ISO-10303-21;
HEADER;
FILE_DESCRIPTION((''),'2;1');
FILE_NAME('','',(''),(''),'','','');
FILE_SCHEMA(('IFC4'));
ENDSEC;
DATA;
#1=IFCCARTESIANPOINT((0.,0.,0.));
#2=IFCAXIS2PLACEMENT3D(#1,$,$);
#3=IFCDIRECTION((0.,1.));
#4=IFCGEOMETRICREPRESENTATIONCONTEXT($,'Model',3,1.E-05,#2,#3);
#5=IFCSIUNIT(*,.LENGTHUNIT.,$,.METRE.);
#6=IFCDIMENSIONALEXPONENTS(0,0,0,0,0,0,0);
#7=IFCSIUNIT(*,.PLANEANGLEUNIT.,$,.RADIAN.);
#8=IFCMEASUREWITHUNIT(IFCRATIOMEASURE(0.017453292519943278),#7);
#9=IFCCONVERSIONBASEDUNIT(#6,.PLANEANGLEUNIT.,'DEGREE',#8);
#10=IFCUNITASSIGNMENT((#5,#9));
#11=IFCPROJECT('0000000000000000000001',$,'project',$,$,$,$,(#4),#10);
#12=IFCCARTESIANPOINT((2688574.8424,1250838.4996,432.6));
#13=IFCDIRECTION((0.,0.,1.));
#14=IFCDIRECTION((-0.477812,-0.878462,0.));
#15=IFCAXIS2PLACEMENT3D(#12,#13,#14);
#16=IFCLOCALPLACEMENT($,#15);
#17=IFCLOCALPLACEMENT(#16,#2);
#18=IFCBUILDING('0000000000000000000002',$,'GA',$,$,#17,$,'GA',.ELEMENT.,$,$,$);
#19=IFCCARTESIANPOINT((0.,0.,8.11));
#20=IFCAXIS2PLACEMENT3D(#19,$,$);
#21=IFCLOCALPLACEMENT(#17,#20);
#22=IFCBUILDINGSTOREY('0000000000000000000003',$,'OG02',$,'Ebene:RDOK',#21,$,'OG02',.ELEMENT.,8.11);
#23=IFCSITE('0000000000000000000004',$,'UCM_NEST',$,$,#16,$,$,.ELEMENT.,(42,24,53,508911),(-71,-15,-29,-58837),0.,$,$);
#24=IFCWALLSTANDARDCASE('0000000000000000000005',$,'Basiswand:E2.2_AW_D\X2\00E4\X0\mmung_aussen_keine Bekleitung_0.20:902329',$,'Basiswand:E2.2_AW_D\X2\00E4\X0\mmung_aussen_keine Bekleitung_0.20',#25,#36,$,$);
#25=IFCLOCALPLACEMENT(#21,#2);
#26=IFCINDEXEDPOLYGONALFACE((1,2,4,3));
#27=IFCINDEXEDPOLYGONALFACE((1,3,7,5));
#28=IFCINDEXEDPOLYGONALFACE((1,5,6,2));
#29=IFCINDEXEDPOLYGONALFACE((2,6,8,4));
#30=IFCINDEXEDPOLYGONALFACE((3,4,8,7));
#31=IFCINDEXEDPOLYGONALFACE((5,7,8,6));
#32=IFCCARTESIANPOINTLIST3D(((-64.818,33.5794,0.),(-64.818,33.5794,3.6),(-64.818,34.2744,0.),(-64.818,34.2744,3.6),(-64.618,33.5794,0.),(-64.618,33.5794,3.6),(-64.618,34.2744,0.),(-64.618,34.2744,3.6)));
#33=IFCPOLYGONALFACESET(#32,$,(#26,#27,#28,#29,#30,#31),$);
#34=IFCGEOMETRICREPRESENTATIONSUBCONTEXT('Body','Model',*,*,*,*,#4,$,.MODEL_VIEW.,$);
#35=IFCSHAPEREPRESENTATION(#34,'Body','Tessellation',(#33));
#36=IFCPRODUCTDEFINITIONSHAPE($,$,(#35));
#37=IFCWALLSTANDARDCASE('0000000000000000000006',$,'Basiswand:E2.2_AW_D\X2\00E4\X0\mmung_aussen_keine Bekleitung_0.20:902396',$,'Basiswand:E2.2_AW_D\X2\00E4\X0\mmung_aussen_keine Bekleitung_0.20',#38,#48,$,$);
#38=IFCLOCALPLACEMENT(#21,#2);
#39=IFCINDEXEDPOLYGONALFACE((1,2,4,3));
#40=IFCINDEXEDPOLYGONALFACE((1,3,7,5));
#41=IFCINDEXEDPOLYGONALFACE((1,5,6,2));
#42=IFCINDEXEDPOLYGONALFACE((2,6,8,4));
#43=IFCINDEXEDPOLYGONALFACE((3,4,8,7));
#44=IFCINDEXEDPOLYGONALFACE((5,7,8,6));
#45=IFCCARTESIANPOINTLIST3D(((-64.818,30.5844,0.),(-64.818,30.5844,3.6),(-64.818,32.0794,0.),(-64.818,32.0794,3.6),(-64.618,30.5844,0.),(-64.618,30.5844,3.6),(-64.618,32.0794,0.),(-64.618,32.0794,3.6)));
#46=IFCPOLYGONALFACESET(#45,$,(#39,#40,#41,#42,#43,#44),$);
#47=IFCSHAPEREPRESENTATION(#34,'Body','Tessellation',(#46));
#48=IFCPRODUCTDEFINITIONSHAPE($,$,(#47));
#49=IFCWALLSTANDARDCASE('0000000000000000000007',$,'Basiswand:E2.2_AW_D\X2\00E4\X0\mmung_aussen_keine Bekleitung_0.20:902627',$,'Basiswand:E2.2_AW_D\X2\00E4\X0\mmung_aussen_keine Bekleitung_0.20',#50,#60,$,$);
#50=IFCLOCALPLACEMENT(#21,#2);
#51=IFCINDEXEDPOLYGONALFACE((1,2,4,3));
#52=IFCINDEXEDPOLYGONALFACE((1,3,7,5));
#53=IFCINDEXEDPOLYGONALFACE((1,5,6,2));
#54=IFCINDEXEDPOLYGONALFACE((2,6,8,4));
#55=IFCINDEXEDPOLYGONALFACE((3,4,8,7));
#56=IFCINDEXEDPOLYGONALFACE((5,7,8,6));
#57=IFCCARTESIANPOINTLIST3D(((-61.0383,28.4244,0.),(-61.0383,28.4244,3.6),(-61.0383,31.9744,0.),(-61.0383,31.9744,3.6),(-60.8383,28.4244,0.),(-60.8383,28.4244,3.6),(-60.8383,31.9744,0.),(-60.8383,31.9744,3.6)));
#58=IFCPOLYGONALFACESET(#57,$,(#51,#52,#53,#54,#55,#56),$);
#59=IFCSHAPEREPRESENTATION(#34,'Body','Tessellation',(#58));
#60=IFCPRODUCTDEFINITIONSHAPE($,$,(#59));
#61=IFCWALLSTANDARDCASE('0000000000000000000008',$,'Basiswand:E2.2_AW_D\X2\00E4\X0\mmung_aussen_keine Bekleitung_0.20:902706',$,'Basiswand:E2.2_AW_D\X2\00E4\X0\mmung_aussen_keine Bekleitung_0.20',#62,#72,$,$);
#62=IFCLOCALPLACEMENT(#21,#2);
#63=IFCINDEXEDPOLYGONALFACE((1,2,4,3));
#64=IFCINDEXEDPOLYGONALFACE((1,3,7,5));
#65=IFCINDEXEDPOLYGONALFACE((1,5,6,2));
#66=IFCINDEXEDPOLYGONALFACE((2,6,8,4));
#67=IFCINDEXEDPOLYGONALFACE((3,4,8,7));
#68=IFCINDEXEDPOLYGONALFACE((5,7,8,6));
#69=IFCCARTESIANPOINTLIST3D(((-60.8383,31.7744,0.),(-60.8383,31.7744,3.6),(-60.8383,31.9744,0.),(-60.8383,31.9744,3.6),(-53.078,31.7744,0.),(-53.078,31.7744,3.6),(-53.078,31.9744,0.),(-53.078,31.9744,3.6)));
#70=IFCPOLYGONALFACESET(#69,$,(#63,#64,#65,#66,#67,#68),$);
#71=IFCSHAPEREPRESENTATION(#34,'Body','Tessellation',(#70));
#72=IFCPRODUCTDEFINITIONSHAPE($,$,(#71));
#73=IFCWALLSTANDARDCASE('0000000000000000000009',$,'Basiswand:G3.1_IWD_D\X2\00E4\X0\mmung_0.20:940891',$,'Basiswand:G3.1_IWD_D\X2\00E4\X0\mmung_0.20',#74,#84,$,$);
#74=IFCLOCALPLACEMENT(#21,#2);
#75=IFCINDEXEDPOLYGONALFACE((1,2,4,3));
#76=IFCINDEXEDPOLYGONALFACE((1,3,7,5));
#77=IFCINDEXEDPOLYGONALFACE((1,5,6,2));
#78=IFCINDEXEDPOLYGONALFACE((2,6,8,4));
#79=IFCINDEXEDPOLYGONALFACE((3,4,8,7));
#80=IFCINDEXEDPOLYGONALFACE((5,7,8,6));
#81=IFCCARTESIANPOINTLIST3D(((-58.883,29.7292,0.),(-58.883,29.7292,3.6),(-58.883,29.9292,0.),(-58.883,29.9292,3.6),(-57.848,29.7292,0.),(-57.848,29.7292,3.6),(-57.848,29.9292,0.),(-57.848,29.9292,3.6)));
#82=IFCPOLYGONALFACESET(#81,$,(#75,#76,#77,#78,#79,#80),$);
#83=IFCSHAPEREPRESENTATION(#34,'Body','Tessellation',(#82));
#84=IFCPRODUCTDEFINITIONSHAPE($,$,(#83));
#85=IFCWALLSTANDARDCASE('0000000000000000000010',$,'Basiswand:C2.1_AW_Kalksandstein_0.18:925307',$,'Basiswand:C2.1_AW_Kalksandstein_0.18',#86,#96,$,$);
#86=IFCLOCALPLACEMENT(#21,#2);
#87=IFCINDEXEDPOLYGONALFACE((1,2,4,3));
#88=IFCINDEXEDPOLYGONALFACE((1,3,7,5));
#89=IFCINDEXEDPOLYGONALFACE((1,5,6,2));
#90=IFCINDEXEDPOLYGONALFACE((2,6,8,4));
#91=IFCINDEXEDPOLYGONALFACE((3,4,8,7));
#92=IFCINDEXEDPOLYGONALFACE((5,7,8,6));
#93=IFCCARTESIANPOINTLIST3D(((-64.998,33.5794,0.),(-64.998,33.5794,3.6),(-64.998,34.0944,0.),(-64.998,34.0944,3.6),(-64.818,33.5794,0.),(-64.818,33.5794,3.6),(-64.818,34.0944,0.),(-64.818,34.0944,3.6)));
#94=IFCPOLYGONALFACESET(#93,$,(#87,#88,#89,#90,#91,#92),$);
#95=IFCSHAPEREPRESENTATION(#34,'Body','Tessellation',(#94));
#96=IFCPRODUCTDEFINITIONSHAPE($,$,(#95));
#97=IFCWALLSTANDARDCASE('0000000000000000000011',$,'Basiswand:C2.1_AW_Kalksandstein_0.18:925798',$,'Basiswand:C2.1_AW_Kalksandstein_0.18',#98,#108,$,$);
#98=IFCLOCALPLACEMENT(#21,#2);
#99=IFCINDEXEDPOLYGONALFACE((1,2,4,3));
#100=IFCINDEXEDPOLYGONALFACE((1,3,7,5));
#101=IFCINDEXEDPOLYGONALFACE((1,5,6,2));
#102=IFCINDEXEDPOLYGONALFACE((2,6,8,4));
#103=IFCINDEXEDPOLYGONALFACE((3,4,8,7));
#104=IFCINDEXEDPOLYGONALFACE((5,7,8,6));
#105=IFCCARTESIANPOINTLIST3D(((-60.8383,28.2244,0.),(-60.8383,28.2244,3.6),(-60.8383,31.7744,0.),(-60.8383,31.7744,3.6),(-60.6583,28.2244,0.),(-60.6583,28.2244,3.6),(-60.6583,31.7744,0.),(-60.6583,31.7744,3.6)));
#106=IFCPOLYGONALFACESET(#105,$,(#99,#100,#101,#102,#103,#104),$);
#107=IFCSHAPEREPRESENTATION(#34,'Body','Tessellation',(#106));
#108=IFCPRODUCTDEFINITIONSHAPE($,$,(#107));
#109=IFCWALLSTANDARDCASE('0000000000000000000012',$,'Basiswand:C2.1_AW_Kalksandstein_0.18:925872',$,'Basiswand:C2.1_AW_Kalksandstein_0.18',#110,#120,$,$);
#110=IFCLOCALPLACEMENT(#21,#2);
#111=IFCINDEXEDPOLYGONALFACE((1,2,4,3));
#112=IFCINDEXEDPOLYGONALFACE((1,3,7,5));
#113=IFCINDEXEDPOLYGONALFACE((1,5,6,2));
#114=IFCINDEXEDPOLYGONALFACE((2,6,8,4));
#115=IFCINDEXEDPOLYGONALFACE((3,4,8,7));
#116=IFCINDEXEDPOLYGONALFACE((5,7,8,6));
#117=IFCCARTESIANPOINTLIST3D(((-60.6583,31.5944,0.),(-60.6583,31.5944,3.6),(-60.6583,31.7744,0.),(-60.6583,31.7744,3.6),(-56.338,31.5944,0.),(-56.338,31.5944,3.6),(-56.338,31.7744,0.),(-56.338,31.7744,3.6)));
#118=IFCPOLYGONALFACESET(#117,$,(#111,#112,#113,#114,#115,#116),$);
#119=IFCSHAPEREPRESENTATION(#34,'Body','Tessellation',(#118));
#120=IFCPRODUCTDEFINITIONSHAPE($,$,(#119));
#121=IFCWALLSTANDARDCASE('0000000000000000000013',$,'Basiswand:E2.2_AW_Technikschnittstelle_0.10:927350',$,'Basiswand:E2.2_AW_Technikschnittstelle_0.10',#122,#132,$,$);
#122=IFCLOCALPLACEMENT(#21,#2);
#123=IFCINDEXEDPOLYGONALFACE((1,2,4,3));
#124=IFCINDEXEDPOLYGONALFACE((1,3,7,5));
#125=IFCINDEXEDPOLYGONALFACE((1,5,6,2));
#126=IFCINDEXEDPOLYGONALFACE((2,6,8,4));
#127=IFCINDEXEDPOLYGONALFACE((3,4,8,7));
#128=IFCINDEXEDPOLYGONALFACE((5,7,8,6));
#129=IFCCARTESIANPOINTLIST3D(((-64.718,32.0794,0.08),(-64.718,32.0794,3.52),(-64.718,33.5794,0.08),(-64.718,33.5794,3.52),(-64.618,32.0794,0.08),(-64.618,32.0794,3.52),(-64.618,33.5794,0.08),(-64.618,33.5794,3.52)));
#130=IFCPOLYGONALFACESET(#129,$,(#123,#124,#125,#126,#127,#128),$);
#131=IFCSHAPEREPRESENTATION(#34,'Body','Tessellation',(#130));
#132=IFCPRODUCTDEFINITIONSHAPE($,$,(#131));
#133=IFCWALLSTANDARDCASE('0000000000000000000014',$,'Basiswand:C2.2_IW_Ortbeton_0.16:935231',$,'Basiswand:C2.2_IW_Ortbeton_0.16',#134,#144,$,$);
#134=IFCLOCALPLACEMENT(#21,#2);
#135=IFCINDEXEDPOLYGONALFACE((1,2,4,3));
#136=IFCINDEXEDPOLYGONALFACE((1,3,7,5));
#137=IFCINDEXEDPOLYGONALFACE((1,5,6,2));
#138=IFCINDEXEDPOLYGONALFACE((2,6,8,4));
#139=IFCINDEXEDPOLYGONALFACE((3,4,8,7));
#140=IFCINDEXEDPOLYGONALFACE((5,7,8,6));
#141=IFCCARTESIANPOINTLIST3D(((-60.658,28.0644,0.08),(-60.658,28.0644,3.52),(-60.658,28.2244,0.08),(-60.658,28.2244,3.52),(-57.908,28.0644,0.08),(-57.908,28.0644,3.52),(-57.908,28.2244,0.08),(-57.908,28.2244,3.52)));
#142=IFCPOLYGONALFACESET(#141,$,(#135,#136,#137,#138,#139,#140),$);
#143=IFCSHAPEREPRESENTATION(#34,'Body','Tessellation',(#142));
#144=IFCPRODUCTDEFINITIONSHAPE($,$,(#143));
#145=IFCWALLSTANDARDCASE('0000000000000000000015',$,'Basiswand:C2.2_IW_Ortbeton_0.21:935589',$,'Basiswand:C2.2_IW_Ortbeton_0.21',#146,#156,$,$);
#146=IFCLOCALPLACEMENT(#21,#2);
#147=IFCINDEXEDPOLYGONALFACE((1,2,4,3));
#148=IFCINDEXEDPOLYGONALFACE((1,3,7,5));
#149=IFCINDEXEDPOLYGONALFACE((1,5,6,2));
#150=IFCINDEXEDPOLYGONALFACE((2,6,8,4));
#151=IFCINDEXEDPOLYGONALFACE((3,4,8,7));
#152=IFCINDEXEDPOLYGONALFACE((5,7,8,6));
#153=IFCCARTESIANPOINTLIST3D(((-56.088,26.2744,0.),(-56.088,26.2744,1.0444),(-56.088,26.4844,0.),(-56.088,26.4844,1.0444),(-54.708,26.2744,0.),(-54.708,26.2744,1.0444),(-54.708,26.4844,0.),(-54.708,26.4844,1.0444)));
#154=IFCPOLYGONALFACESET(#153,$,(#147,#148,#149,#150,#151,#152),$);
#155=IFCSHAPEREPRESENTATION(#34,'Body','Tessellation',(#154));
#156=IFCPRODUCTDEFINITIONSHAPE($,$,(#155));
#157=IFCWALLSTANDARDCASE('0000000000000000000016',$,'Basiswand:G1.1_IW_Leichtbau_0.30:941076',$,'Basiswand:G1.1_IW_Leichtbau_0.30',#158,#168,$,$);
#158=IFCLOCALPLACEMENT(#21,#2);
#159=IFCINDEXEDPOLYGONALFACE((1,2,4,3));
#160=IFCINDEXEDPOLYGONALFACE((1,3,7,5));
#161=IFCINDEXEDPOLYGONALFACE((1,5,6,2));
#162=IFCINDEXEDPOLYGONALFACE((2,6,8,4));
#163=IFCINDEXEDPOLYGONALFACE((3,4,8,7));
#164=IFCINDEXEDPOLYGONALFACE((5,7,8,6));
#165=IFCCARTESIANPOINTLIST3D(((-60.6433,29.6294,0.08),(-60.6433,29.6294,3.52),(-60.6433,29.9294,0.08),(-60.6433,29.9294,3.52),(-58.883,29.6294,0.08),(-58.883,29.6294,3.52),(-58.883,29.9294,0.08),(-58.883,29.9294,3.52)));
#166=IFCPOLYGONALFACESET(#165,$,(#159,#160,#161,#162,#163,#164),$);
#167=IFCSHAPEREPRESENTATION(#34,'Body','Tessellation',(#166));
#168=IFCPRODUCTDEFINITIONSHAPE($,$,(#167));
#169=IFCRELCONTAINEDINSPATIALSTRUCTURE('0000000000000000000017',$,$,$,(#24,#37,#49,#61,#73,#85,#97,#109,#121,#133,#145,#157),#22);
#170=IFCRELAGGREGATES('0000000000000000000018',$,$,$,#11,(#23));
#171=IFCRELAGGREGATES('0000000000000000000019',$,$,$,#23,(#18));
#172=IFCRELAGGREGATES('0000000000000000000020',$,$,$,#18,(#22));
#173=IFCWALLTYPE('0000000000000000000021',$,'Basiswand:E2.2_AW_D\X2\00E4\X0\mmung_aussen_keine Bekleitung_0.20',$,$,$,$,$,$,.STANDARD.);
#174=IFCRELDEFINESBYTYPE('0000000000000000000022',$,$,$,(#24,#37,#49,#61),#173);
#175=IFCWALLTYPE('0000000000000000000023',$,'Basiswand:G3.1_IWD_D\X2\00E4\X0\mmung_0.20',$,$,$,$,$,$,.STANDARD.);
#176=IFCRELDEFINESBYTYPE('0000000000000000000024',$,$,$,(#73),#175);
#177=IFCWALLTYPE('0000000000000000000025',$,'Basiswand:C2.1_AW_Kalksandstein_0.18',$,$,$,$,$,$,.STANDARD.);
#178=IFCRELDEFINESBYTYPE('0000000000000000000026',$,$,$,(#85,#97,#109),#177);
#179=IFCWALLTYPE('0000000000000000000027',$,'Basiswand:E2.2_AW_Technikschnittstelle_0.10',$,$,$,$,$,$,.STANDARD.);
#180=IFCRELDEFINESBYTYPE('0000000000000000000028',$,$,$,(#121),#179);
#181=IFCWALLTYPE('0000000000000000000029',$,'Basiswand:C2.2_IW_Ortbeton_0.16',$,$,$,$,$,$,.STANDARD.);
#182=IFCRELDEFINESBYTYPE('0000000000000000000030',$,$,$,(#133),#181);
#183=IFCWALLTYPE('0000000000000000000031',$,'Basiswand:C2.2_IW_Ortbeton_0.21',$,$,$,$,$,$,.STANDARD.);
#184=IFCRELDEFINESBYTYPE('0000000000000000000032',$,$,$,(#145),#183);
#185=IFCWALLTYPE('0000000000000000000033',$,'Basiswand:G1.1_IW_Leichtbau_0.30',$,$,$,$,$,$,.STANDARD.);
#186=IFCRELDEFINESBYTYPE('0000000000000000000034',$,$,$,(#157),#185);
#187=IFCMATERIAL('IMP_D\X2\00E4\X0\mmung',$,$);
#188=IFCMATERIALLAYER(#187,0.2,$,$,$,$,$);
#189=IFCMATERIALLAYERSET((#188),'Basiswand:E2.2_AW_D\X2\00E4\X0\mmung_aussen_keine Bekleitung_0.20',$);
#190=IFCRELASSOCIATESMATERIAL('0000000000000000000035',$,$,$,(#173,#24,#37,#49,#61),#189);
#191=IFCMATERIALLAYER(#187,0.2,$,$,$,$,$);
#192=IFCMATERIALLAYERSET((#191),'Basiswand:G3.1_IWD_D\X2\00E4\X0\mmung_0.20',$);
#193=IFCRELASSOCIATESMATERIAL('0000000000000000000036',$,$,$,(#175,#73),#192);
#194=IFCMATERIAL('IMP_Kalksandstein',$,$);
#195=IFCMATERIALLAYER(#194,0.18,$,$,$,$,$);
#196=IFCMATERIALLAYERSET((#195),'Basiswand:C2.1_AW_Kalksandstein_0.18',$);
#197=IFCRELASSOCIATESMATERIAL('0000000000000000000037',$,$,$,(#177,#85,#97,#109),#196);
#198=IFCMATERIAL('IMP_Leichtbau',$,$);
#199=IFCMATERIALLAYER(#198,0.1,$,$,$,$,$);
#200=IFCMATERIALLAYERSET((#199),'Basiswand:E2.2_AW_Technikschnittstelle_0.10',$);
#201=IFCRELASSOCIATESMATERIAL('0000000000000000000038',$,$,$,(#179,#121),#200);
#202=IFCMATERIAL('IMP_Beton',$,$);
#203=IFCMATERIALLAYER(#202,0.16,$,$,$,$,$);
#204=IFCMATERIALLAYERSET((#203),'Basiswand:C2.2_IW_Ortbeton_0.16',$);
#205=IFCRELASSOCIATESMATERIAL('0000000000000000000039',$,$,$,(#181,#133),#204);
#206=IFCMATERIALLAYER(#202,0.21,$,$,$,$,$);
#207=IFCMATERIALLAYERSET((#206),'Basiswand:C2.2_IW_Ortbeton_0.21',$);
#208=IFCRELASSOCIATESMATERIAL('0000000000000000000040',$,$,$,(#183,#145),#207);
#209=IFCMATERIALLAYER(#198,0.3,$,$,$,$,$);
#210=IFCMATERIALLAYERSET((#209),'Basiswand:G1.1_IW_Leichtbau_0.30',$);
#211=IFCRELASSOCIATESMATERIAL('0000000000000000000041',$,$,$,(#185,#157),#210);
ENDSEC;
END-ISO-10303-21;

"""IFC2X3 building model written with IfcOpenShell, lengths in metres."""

from ifc_helpers import new_model, entity, si_unit, converted_unit, direction, frame, frame_2d, origin, place, context, subcontext, project, spatial, polyline, rectangle, extrude, clip, bounded_halfspace, material, layer, layer_set, layer_usage, type_object, element, save


model = new_model("IFC2X3")

# Units and contexts
model_context = context("Model", 3, precision=1e-05, world=origin(), true_north=direction((0.0, 1.0)))
body_context = subcontext(model_context, "Body", "Model", "MODEL_VIEW")
ifc_project = project(units=[si_unit("LENGTHUNIT", "METRE"), converted_unit("PLANEANGLEUNIT", "DEGREE", entity("IfcRatioMeasure", 0.017453292519943278), si_unit("PLANEANGLEUNIT", "RADIAN"), dimensions=[0, 0, 0, 0, 0, 0, 0])], contexts=[model_context])

# Site, building, storey
site_placement = place(None, frame((2688574.8424, 1250838.4996, 432.6), z_axis=(0.0, 0.0, 1.0), x_axis=(-0.477812, -0.878462, 0.0)))
site = spatial("IfcSite", under=ifc_project, at=site_placement, Name="UCM_NEST", CompositionType="ELEMENT", RefLatitude=(42, 24, 53, 508911), RefLongitude=(-71, -15, -29, -58837), RefElevation=0.0)
building_placement = place(site_placement, origin())
building = spatial("IfcBuilding", under=site, at=building_placement, Name="GA", LongName="GA", CompositionType="ELEMENT")
storey_placement = place(building_placement, frame((0.0, 0.0, 8.11)))
storey = spatial("IfcBuildingStorey", under=building, at=storey_placement, Name="OG02", ObjectType="Ebene:RDOK", LongName="OG02", CompositionType="ELEMENT", Elevation=8.11)

# Walls
ifc_material_1 = material(Name="IMP_Dämmung")
ifc_layer_1 = layer(ifc_material_1, 0.2)
ifc_layer_set_1 = layer_set([ifc_layer_1], Name="Basiswand:E2.2_AW_Dämmung_aussen_keine Bekleitung_0.20")
ifc_layer_usage_1 = layer_usage(ifc_layer_set_1, "AXIS2", "NEGATIVE", 0.1)
wall_type_1 = type_object("IfcWallType", Name="Basiswand:E2.2_AW_Dämmung_aussen_keine Bekleitung_0.20", PredefinedType="STANDARD", material=ifc_layer_set_1)
wall_1_placement = place(storey_placement, frame((-64.718, 34.2744, 0.0), z_axis=(0.0, 0.0, 1.0), x_axis=(0.0, -1.0, 0.0)))
element("IfcWallStandardCase", 1, at=wall_1_placement, inside=storey, type_object=wall_type_1, material=ifc_layer_usage_1, Name="Basiswand:E2.2_AW_Dämmung_aussen_keine Bekleitung_0.20:902329", ObjectType="Basiswand:E2.2_AW_Dämmung_aussen_keine Bekleitung_0.20", context=body_context, shape_type="SweptSolid", body=[
    extrude(rectangle(XDim=0.695, YDim=0.2, at=frame_2d((0.3475, 0.0), x_axis=(-1.0, 0.0))), origin(), (0.0, 0.0, 1.0), 3.6),
])
wall_2_placement = place(storey_placement, frame((-64.718, 32.0794, 0.0), z_axis=(0.0, 0.0, 1.0), x_axis=(0.0, -1.0, 0.0)))
element("IfcWallStandardCase", 2, at=wall_2_placement, inside=storey, type_object=wall_type_1, material=ifc_layer_usage_1, Name="Basiswand:E2.2_AW_Dämmung_aussen_keine Bekleitung_0.20:902396", ObjectType="Basiswand:E2.2_AW_Dämmung_aussen_keine Bekleitung_0.20", context=body_context, shape_type="SweptSolid", body=[
    extrude(rectangle(XDim=1.495, YDim=0.2, at=frame_2d((0.7475, 0.0), x_axis=(-1.0, 0.0))), origin(), (0.0, 0.0, 1.0), 3.6),
])
wall_3_placement = place(storey_placement, frame((-60.9383, 28.4244, 0.0), z_axis=(0.0, 0.0, 1.0), x_axis=(0.0, 1.0, 0.0)))
element("IfcWallStandardCase", 3, at=wall_3_placement, inside=storey, type_object=wall_type_1, material=ifc_layer_usage_1, Name="Basiswand:E2.2_AW_Dämmung_aussen_keine Bekleitung_0.20:902627", ObjectType="Basiswand:E2.2_AW_Dämmung_aussen_keine Bekleitung_0.20", context=body_context, shape_type="SweptSolid", body=[
    extrude(rectangle(XDim=3.55, YDim=0.2, at=frame_2d((1.775, 0.0), x_axis=(-1.0, 0.0))), origin(), (0.0, 0.0, 1.0), 3.6),
])
wall_4_placement = place(storey_placement, frame((-60.8383, 31.8744, 0.0)))
element("IfcWallStandardCase", 4, at=wall_4_placement, inside=storey, type_object=wall_type_1, material=ifc_layer_usage_1, Name="Basiswand:E2.2_AW_Dämmung_aussen_keine Bekleitung_0.20:902706", ObjectType="Basiswand:E2.2_AW_Dämmung_aussen_keine Bekleitung_0.20", context=body_context, shape_type="SweptSolid", body=[
    extrude(rectangle(XDim=7.7603, YDim=0.2, at=frame_2d((3.8801, 0.0), x_axis=(-1.0, 0.0))), origin(), (0.0, 0.0, 1.0), 3.6),
])
ifc_layer_2 = layer(ifc_material_1, 0.2)
ifc_layer_set_2 = layer_set([ifc_layer_2], Name="Basiswand:G3.1_IWD_Dämmung_0.20")
ifc_layer_usage_2 = layer_usage(ifc_layer_set_2, "AXIS2", "NEGATIVE", 0.1)
wall_type_2 = type_object("IfcWallType", Name="Basiswand:G3.1_IWD_Dämmung_0.20", PredefinedType="STANDARD", material=ifc_layer_set_2)
wall_5_placement = place(storey_placement, frame((-57.848, 29.8292, 0.0), z_axis=(0.0, 0.0, 1.0), x_axis=(-1.0, 0.0, 0.0)))
element("IfcWallStandardCase", 5, at=wall_5_placement, inside=storey, type_object=wall_type_2, material=ifc_layer_usage_2, Name="Basiswand:G3.1_IWD_Dämmung_0.20:940891", ObjectType="Basiswand:G3.1_IWD_Dämmung_0.20", context=body_context, shape_type="SweptSolid", body=[
    extrude(rectangle(XDim=1.035, YDim=0.2, at=frame_2d((0.5175, 0.0), x_axis=(-1.0, 0.0))), origin(), (0.0, 0.0, 1.0), 3.6),
])
ifc_material_2 = material(Name="IMP_Kalksandstein")
ifc_layer_3 = layer(ifc_material_2, 0.18)
ifc_layer_set_3 = layer_set([ifc_layer_3], Name="Basiswand:C2.1_AW_Kalksandstein_0.18")
ifc_layer_usage_3 = layer_usage(ifc_layer_set_3, "AXIS2", "NEGATIVE", 0.09)
wall_type_3 = type_object("IfcWallType", Name="Basiswand:C2.1_AW_Kalksandstein_0.18", PredefinedType="STANDARD", material=ifc_layer_set_3)
wall_6_placement = place(storey_placement, frame((-64.908, 34.0944, 0.0), z_axis=(0.0, 0.0, 1.0), x_axis=(0.0, -1.0, 0.0)))
element("IfcWallStandardCase", 6, at=wall_6_placement, inside=storey, type_object=wall_type_3, material=ifc_layer_usage_3, Name="Basiswand:C2.1_AW_Kalksandstein_0.18:925307", ObjectType="Basiswand:C2.1_AW_Kalksandstein_0.18", context=body_context, shape_type="SweptSolid", body=[
    extrude(rectangle(XDim=0.515, YDim=0.18, at=frame_2d((0.2575, 0.0), x_axis=(-1.0, 0.0))), origin(), (0.0, 0.0, 1.0), 3.6),
])
wall_7_placement = place(storey_placement, frame((-60.7483, 28.2244, 0.0), z_axis=(0.0, 0.0, 1.0), x_axis=(0.0, 1.0, 0.0)))
element("IfcWallStandardCase", 7, at=wall_7_placement, inside=storey, type_object=wall_type_3, material=ifc_layer_usage_3, Name="Basiswand:C2.1_AW_Kalksandstein_0.18:925798", ObjectType="Basiswand:C2.1_AW_Kalksandstein_0.18", context=body_context, shape_type="SweptSolid", body=[
    extrude(rectangle(XDim=3.55, YDim=0.18, at=frame_2d((1.775, 0.0), x_axis=(-1.0, 0.0))), origin(), (0.0, 0.0, 1.0), 3.6),
])
wall_8_placement = place(storey_placement, frame((-60.6583, 31.6844, 0.0)))
element("IfcWallStandardCase", 8, at=wall_8_placement, inside=storey, type_object=wall_type_3, material=ifc_layer_usage_3, Name="Basiswand:C2.1_AW_Kalksandstein_0.18:925872", ObjectType="Basiswand:C2.1_AW_Kalksandstein_0.18", context=body_context, shape_type="SweptSolid", body=[
    extrude(rectangle(XDim=4.3203, YDim=0.18, at=frame_2d((2.1601, 0.0), x_axis=(-1.0, 0.0))), origin(), (0.0, 0.0, 1.0), 3.6),
])
ifc_material_3 = material(Name="IMP_Leichtbau")
ifc_layer_4 = layer(ifc_material_3, 0.1)
ifc_layer_set_4 = layer_set([ifc_layer_4], Name="Basiswand:E2.2_AW_Technikschnittstelle_0.10")
ifc_layer_usage_4 = layer_usage(ifc_layer_set_4, "AXIS2", "NEGATIVE", 0.05)
wall_type_4 = type_object("IfcWallType", Name="Basiswand:E2.2_AW_Technikschnittstelle_0.10", PredefinedType="STANDARD", material=ifc_layer_set_4)
wall_9_placement = place(storey_placement, frame((-64.668, 33.5794, 0.08), z_axis=(0.0, 0.0, 1.0), x_axis=(0.0, -1.0, 0.0)))
element("IfcWallStandardCase", 9, at=wall_9_placement, inside=storey, type_object=wall_type_4, material=ifc_layer_usage_4, Name="Basiswand:E2.2_AW_Technikschnittstelle_0.10:927350", ObjectType="Basiswand:E2.2_AW_Technikschnittstelle_0.10", context=body_context, shape_type="Clipping", body=[
    clip(clip(extrude(rectangle(XDim=1.5, YDim=0.1, at=frame_2d((0.75, 0.0), x_axis=(-1.0, 0.0))), origin(), (0.0, 0.0, 1.0), 3.44), bounded_halfspace(frame((1.5, -0.05, 0.0), z_axis=(0.0, 0.0, 1.0), x_axis=(0.0, -1.0, 0.0)), True, frame((1.5, -0.05, 0.0), z_axis=(0.0, 0.0, 1.0), x_axis=(0.0, -1.0, 0.0)), polyline([(0.0, 0.0), (-0.1, 0.0), (-0.1, -1.5), (0.0, -1.5), (0.0, 0.0)]))), bounded_halfspace(frame((0.0, -0.05, 3.44), z_axis=(0.0, 0.0, -1.0), x_axis=(0.0, -1.0, 0.0)), True, frame((0.0, -0.05, 3.44), z_axis=(0.0, 0.0, -1.0), x_axis=(0.0, -1.0, 0.0)), polyline([(0.0, 0.0), (-0.1, 0.0), (-0.1, -1.5), (0.0, -1.5), (0.0, 0.0)]))),
])
ifc_material_4 = material(Name="IMP_Beton")
ifc_layer_5 = layer(ifc_material_4, 0.16)
ifc_layer_set_5 = layer_set([ifc_layer_5], Name="Basiswand:C2.2_IW_Ortbeton_0.16")
ifc_layer_usage_5 = layer_usage(ifc_layer_set_5, "AXIS2", "NEGATIVE", 0.08)
wall_type_5 = type_object("IfcWallType", Name="Basiswand:C2.2_IW_Ortbeton_0.16", PredefinedType="STANDARD", material=ifc_layer_set_5)
wall_10_placement = place(storey_placement, frame((-60.658, 28.1444, 0.08)))
element("IfcWallStandardCase", 10, at=wall_10_placement, inside=storey, type_object=wall_type_5, material=ifc_layer_usage_5, Name="Basiswand:C2.2_IW_Ortbeton_0.16:935231", ObjectType="Basiswand:C2.2_IW_Ortbeton_0.16", context=body_context, shape_type="Clipping", body=[
    clip(clip(extrude(rectangle(XDim=2.75, YDim=0.16, at=frame_2d((1.375, 0.0), x_axis=(-1.0, 0.0))), origin(), (0.0, 0.0, 1.0), 3.44), bounded_halfspace(frame((2.75, -0.08, 0.0), z_axis=(0.0, 0.0, 1.0), x_axis=(-1.0, 0.0, 0.0)), True, frame((2.75, -0.08, 0.0), z_axis=(0.0, 0.0, 1.0), x_axis=(-1.0, 0.0, 0.0)), polyline([(0.0, 0.0), (0.0, -0.16), (2.75, -0.16), (2.75, 0.0), (0.0, 0.0)]))), bounded_halfspace(frame((0.0, -0.08, 3.44), z_axis=(0.0, 0.0, -1.0), x_axis=(-1.0, 0.0, 0.0)), True, frame((0.0, -0.08, 3.44), z_axis=(0.0, 0.0, -1.0), x_axis=(-1.0, 0.0, 0.0)), polyline([(0.0, 0.0), (0.0, 0.16), (-2.75, 0.16), (-2.75, 0.0), (0.0, 0.0)]))),
])
ifc_layer_6 = layer(ifc_material_4, 0.21)
ifc_layer_set_6 = layer_set([ifc_layer_6], Name="Basiswand:C2.2_IW_Ortbeton_0.21")
ifc_layer_usage_6 = layer_usage(ifc_layer_set_6, "AXIS2", "NEGATIVE", 0.105)
wall_type_6 = type_object("IfcWallType", Name="Basiswand:C2.2_IW_Ortbeton_0.21", PredefinedType="STANDARD", material=ifc_layer_set_6)
wall_11_placement = place(storey_placement, frame((-56.088, 26.3794, 0.0)))
element("IfcWallStandardCase", 11, at=wall_11_placement, inside=storey, type_object=wall_type_6, material=ifc_layer_usage_6, Name="Basiswand:C2.2_IW_Ortbeton_0.21:935589", ObjectType="Basiswand:C2.2_IW_Ortbeton_0.21", context=body_context, shape_type="SweptSolid", body=[
    extrude(rectangle(XDim=1.38, YDim=0.21, at=frame_2d((0.69, 0.0), x_axis=(-1.0, 0.0))), origin(), (0.0, 0.0, 1.0), 1.0444),
])
ifc_layer_7 = layer(ifc_material_3, 0.3)
ifc_layer_set_7 = layer_set([ifc_layer_7], Name="Basiswand:G1.1_IW_Leichtbau_0.30")
ifc_layer_usage_7 = layer_usage(ifc_layer_set_7, "AXIS2", "NEGATIVE", 0.15)
wall_type_7 = type_object("IfcWallType", Name="Basiswand:G1.1_IW_Leichtbau_0.30", PredefinedType="STANDARD", material=ifc_layer_set_7)
wall_12_placement = place(storey_placement, frame((-60.6433, 29.7794, 0.08)))
element("IfcWallStandardCase", 12, at=wall_12_placement, inside=storey, type_object=wall_type_7, material=ifc_layer_usage_7, Name="Basiswand:G1.1_IW_Leichtbau_0.30:941076", ObjectType="Basiswand:G1.1_IW_Leichtbau_0.30", context=body_context, shape_type="Clipping", body=[
    clip(clip(extrude(rectangle(XDim=1.7603, YDim=0.3, at=frame_2d((0.8801, 0.0), x_axis=(-1.0, 0.0))), origin(), (0.0, 0.0, 1.0), 3.44), bounded_halfspace(frame((1.7603, -0.15, 0.0), z_axis=(0.0, 0.0, 1.0), x_axis=(-1.0, 0.0, 0.0)), True, frame((1.7603, -0.15, 0.0), z_axis=(0.0, 0.0, 1.0), x_axis=(-1.0, 0.0, 0.0)), polyline([(0.0, 0.0), (0.0, -0.3), (1.7603, -0.3), (1.7603, 0.0), (0.0, 0.0)]))), bounded_halfspace(frame((0.0, -0.15, 3.44), z_axis=(0.0, 0.0, -1.0), x_axis=(-1.0, 0.0, 0.0)), True, frame((0.0, -0.15, 3.44), z_axis=(0.0, 0.0, -1.0), x_axis=(-1.0, 0.0, 0.0)), polyline([(0.0, 0.0), (0.0, 0.3), (-1.7603, 0.3), (-1.7603, 0.0), (0.0, 0.0)]))),
])

save(model, "model.ifc")
